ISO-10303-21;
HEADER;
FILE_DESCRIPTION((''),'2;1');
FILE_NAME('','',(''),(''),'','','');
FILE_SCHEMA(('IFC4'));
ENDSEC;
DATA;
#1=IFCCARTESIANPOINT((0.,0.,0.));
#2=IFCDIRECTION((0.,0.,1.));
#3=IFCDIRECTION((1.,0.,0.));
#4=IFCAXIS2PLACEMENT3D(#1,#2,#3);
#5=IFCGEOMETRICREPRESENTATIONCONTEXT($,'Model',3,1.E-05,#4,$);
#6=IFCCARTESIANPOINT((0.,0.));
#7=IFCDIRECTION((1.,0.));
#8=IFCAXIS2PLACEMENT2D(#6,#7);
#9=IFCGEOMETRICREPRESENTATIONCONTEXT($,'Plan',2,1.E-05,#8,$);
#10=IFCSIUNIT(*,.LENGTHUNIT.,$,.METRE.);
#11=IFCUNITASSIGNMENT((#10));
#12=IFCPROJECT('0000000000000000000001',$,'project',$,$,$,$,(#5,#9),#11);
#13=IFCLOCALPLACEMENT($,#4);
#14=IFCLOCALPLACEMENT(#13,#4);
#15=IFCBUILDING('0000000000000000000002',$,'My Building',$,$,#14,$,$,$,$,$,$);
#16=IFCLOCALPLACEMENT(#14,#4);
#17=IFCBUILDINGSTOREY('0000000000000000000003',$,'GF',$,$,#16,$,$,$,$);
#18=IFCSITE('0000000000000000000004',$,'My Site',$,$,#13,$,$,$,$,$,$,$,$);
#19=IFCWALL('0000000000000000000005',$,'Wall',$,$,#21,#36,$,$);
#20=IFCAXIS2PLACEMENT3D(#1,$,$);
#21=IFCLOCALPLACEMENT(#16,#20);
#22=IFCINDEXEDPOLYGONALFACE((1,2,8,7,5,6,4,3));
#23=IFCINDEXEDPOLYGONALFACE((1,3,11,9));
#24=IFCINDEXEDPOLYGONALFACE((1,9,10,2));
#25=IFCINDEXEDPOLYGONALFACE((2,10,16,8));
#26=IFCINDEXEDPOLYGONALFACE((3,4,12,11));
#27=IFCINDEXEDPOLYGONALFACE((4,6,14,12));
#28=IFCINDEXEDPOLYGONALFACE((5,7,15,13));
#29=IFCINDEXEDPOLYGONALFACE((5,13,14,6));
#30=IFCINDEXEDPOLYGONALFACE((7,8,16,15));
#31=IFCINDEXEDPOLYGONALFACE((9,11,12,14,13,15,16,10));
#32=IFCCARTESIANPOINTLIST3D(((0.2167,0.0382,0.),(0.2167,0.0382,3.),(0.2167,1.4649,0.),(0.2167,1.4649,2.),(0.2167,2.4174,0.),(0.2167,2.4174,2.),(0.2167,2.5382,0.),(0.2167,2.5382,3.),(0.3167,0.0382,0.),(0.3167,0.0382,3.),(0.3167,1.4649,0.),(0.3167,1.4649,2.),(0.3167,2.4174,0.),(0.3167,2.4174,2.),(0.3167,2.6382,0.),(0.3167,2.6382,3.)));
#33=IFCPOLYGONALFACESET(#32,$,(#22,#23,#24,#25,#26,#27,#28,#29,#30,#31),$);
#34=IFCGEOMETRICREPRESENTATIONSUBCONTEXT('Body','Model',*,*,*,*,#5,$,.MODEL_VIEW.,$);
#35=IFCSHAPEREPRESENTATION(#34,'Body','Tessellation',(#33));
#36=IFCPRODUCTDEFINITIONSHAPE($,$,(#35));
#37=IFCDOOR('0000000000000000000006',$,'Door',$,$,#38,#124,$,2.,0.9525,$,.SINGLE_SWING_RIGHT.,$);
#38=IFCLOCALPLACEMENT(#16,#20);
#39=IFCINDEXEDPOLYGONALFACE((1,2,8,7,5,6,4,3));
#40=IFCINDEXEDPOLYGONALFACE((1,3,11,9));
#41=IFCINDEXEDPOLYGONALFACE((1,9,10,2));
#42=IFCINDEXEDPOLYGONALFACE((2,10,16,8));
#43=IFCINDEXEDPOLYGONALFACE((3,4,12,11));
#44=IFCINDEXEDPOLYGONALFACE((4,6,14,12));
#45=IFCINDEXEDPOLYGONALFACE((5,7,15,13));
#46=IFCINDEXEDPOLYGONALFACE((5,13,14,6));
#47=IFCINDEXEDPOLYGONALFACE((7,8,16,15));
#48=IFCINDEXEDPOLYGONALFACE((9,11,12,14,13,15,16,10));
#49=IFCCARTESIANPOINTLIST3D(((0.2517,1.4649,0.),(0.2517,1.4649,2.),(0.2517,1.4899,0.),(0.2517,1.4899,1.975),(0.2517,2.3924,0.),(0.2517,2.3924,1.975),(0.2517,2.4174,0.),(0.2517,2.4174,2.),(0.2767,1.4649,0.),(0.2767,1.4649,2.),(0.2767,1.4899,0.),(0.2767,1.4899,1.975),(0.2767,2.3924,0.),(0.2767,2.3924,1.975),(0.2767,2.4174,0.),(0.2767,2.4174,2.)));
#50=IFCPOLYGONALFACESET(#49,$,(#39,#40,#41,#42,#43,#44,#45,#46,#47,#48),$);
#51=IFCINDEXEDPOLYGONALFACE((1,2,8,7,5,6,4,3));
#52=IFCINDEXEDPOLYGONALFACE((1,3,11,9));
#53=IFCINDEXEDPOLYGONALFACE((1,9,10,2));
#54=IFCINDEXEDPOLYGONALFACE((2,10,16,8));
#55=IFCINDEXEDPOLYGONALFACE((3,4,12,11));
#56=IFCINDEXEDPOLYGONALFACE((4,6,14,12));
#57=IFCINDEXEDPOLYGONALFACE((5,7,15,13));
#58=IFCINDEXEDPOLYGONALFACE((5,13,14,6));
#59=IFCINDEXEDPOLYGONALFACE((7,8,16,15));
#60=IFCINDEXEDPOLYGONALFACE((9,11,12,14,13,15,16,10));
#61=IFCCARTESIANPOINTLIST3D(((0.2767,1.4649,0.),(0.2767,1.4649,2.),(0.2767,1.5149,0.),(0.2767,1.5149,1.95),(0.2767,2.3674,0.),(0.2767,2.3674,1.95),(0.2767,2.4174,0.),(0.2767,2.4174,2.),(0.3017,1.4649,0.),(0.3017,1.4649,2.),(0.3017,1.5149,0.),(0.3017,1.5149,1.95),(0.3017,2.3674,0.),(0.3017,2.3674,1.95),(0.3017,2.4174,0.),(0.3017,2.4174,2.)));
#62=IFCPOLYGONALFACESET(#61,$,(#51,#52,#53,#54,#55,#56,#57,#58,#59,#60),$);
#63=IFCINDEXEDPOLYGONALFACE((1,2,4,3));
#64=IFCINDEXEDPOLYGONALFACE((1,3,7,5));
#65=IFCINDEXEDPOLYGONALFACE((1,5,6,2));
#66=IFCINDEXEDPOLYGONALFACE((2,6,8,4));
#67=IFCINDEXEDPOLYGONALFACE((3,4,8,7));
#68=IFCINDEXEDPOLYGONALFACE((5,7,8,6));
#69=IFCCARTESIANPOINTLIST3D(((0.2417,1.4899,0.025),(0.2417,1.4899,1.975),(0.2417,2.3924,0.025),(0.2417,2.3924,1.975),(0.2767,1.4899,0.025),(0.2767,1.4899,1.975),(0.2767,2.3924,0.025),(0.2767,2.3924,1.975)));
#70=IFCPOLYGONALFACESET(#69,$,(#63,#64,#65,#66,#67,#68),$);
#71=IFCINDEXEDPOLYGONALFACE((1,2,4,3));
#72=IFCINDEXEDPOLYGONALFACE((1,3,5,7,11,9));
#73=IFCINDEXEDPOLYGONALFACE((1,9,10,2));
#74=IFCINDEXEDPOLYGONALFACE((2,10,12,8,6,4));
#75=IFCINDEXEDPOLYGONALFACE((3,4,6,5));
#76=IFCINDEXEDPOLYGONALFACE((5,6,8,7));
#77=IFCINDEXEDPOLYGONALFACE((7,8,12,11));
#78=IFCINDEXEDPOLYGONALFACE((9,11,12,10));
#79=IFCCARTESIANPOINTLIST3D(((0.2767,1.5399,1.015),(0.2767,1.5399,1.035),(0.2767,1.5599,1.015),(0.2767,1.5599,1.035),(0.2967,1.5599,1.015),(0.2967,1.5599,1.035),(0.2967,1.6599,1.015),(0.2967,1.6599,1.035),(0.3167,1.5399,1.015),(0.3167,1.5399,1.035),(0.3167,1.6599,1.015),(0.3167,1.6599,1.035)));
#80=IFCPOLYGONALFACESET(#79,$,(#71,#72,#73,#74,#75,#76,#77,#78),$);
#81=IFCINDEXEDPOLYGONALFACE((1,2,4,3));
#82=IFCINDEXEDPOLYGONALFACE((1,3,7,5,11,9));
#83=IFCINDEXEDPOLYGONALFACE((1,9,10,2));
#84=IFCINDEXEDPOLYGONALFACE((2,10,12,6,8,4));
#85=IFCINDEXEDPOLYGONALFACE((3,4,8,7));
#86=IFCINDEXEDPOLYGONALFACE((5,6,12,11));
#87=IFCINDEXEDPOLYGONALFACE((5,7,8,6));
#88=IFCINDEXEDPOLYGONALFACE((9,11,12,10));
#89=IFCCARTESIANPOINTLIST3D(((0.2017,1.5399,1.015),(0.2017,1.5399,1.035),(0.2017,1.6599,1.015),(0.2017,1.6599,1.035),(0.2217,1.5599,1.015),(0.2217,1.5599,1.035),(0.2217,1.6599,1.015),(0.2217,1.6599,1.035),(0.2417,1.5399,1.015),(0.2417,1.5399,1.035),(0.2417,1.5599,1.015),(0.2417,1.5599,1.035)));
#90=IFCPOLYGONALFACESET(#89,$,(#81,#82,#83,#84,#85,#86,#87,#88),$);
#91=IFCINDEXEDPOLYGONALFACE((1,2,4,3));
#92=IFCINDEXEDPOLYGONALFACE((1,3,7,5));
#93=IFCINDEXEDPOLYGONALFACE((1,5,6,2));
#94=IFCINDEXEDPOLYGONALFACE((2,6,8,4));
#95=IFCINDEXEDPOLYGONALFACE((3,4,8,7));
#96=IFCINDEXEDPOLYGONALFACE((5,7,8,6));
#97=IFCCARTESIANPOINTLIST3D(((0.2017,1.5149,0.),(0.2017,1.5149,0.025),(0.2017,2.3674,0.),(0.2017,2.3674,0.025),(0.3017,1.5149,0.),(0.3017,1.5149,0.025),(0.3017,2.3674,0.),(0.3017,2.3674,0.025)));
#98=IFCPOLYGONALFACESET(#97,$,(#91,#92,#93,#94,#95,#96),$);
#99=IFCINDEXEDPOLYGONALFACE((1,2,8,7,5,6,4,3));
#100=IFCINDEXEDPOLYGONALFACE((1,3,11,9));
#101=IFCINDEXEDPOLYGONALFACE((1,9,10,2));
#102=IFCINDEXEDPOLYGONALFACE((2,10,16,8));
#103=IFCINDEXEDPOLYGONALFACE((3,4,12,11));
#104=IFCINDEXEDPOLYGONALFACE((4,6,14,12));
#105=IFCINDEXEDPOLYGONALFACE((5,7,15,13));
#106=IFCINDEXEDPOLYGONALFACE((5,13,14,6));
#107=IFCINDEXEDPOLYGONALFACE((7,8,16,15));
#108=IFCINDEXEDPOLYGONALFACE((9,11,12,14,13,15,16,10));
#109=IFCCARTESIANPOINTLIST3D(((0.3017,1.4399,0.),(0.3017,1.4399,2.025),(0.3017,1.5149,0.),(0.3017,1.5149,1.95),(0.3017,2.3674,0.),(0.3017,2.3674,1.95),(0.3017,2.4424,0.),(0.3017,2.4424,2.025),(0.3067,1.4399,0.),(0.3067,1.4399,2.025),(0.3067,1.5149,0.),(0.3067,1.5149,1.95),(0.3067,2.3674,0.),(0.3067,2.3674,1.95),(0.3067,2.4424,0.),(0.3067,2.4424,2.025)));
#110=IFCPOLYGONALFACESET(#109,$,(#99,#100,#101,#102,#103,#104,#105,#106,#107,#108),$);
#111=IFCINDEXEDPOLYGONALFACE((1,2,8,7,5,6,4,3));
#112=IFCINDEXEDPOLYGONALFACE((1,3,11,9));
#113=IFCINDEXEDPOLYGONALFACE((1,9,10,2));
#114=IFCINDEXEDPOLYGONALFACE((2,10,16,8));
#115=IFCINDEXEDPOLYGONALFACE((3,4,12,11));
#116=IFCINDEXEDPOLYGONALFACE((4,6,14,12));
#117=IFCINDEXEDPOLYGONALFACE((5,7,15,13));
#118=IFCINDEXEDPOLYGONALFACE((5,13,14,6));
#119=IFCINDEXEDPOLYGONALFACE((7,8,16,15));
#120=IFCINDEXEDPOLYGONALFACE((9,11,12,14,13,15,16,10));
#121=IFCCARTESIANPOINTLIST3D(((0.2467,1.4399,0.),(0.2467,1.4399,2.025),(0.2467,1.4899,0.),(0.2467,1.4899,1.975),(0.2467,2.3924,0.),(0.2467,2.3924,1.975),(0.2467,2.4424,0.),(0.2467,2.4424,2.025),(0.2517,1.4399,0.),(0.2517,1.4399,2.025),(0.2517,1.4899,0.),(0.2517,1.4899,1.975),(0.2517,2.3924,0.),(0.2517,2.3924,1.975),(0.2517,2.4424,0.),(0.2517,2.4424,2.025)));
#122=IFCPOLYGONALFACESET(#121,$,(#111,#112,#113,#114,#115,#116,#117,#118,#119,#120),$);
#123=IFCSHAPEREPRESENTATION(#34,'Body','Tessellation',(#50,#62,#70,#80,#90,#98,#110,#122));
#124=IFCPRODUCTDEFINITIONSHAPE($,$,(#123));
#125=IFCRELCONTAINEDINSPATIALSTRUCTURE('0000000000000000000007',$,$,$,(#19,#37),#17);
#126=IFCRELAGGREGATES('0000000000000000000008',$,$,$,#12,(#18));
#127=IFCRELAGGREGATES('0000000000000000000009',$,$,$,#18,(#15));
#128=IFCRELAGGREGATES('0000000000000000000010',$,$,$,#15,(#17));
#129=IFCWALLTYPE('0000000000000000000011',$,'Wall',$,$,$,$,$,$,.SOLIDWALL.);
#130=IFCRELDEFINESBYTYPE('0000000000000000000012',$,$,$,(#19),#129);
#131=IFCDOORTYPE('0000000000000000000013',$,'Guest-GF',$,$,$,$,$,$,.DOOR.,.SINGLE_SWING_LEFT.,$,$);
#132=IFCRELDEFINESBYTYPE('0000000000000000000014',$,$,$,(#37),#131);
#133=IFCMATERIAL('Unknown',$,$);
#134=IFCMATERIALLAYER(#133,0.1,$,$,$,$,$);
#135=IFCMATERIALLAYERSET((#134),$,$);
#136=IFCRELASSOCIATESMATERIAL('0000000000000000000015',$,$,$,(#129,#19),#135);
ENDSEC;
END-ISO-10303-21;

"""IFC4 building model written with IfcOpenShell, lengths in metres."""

from ifc_helpers import new_model, entity, si_unit, frame, origin_with_axes, origin_2d_with_axis, place, context, subcontext, project, spatial, line, indexed_curve, outline, extrude, shape, source, transform, mapped, material, layer, layer_set, layer_usage, type_object, type_shapes, element, fill, save


model = new_model("IFC4")

# Units and contexts
model_context = context("Model", 3, precision=1e-05, world=origin_with_axes())
plan_context = context("Plan", 2, precision=1e-05, world=origin_2d_with_axis())
body_context_1 = subcontext(model_context, "Body", "Model", "MODEL_VIEW")
body_context_2 = subcontext(plan_context, "Body", "Plan", "PLAN_VIEW")
ifc_project = project(units=[si_unit("LENGTHUNIT", "METRE")], contexts=[model_context, plan_context])

# Site, building, storey
site_placement = place(None, origin_with_axes())
site = spatial("IfcSite", under=ifc_project, at=site_placement, Name="My Site")
building_placement = place(site_placement, origin_with_axes())
building = spatial("IfcBuilding", under=site, at=building_placement, Name="My Building")
storey_placement = place(building_placement, origin_with_axes())
storey = spatial("IfcBuildingStorey", under=building, at=storey_placement, Name="GF")

# Shared definitions
ifc_material = material(Name="Unknown")

# Shared definitions
ifc_layer_1 = layer(ifc_material, 0.1)
ifc_layer_set_1 = layer_set([ifc_layer_1])
wall_type = type_object("IfcWallType", Name="Wall", PredefinedType="SOLIDWALL", material=ifc_layer_set_1)

# Wall, opening, door
ifc_layer_usage_1 = layer_usage(ifc_layer_set_1, "AXIS2", "POSITIVE", 0.0)
wall_1_placement = place(storey_placement, frame((0.3167, 0.0382, 0.0), z_axis=(0.0, 0.0, 1.0), x_axis=(0.0, 1.0, 0.0)))
wall_1 = element("IfcWall", 1, at=wall_1_placement, inside=storey, type_object=wall_type, material=ifc_layer_usage_1, Name="Wall", context=body_context_1, shape_type="SweptSolid", body=[
    extrude(outline(indexed_curve([(0.0, 0.0), (0.0, 0.1), (2.5, 0.1), (2.6, 0.0)], segments=[line(1, 2, 3, 4, 1)])), origin_with_axes(), (0.0, 0.0, 1.0), 3.0),
])
shared_shape_1 = source(origin_with_axes(), body_context_1, "Body", "SweptSolid", [
    extrude(outline(indexed_curve([(0.0, 0.0), (0.9525, 0.0), (0.9525, 2.0), (0.0, 2.0)], segments=[line(1, 2, 3, 4, 1)])), frame((0.0, -0.6, 0.0), z_axis=(0.0, -1.0, 0.0), x_axis=(1.0, 0.0, 0.0)), (0.0, 0.0, -1.0), 1.2),
])
opening_1_placement = place(wall_1_placement, frame((1.4267, 0.015, 0.0), z_axis=(0.0, 0.0, 1.0), x_axis=(1.0, 0.0, 0.0)))
opening_1 = element("IfcOpeningElement", 2, at=opening_1_placement, cuts=wall_1, PredefinedType="OPENING", context=body_context_1, shape_type="MappedRepresentation", body=[
    mapped(shared_shape_1, transform((0.0, 0.0, 0.0), x_axis=(1.0, 0.0, 0.0), y_axis=(0.0, 1.0, 0.0), z_axis=(0.0, 0.0, 1.0), scale=1.0)),
])
door_type_1 = type_object("IfcDoorType", Name="Guest-GF", OperationType="SINGLE_SWING_LEFT", PredefinedType="DOOR")
shared_shape_2 = source(origin_with_axes(), body_context_1, "Body", "SweptSolid", [
    extrude(outline(indexed_curve([(0.0, 0.0), (0.0, 2.0), (0.9525, 2.0), (0.9525, 0.0), (0.9275, 0.0), (0.9275, 1.975), (0.025, 1.975), (0.025, 0.0)], segments=[line(1, 2, 3, 4, 5, 6, 7, 8, 1)])), frame((0.0, 0.025, 0.0), z_axis=(0.0, -1.0, 0.0), x_axis=(1.0, 0.0, 0.0)), (0.0, 0.0, -1.0), 0.025),
    extrude(outline(indexed_curve([(0.0, 0.0), (0.0, 2.0), (0.9525, 2.0), (0.9525, 0.0), (0.9025, 0.0), (0.9025, 1.95), (0.05, 1.95), (0.05, 0.0)], segments=[line(1, 2, 3, 4, 5, 6, 7, 8, 1)])), frame((0.0, 0.0, 0.0), z_axis=(0.0, -1.0, 0.0), x_axis=(1.0, 0.0, 0.0)), (0.0, 0.0, -1.0), 0.025),
    extrude(outline(indexed_curve([(0.0, 0.0), (0.9025, 0.0), (0.9025, 0.035), (0.0, 0.035)], segments=[line(1, 2, 3, 4, 1)])), frame((0.025, 0.025, 0.025), z_axis=(0.0, 0.0, 1.0), x_axis=(1.0, 0.0, 0.0)), (0.0, 0.0, 1.0), 1.95),
    extrude(outline(indexed_curve([(0.0, 0.0), (0.0, -0.04), (0.12, -0.04), (0.12, -0.02), (0.02, -0.02), (0.02, 0.0)], segments=[line(1, 2, 3, 4, 5, 6, 1)])), frame((0.075, 0.025, 1.015), z_axis=(0.0, 0.0, 1.0), x_axis=(1.0, 0.0, 0.0)), (0.0, 0.0, 1.0), 0.02),
    extrude(outline(indexed_curve([(0.0, 0.0), (0.0, 0.04), (0.12, 0.04), (0.12, 0.02), (0.02, 0.02), (0.02, 0.0)], segments=[line(1, 2, 3, 4, 5, 6, 1)])), frame((0.075, 0.06, 1.015), z_axis=(0.0, 0.0, 1.0), x_axis=(1.0, 0.0, 0.0)), (0.0, 0.0, 1.0), 0.02),
    extrude(outline(indexed_curve([(0.0, 0.0), (0.8525, 0.0), (0.8525, 0.1), (0.0, 0.1)], segments=[line(1, 2, 3, 4, 1)])), frame((0.05, 0.0, 0.0), z_axis=(0.0, 0.0, 1.0), x_axis=(1.0, 0.0, 0.0)), (0.0, 0.0, 1.0), 0.025),
    extrude(outline(indexed_curve([(0.0, 0.0), (0.0, 2.025), (1.0025, 2.025), (1.0025, 0.0), (0.9275, 0.0), (0.9275, 1.95), (0.075, 1.95), (0.075, 0.0)], segments=[line(1, 2, 3, 4, 5, 6, 7, 8, 1)])), frame((-0.025, -0.005, 0.0), z_axis=(0.0, -1.0, 0.0), x_axis=(1.0, 0.0, 0.0)), (0.0, 0.0, -1.0), 0.005),
    extrude(outline(indexed_curve([(0.0, 0.0), (0.0, 2.025), (1.0025, 2.025), (1.0025, 0.0), (0.9525, 0.0), (0.9525, 1.975), (0.05, 1.975), (0.05, 0.0)], segments=[line(1, 2, 3, 4, 5, 6, 7, 8, 1)])), frame((-0.025, 0.05, 0.0), z_axis=(0.0, -1.0, 0.0), x_axis=(1.0, 0.0, 0.0)), (0.0, 0.0, -1.0), 0.005),
])
shared_shape_3 = source(origin_with_axes(), body_context_2, "Body", "Curve2D", [
    entity("IfcIndexedPolyCurve", entity("IfcCartesianPointList2D", [[0.0, 0.0], [0.0, 0.05], [0.025, 0.05], [0.025, 0.025], [0.05, 0.025], [0.05, 0.0]]), [entity("IfcLineIndex", [1, 2, 3, 4, 5, 6, 1])]),
    entity("IfcIndexedPolyCurve", entity("IfcCartesianPointList2D", [[0.9525, 0.0], [0.9525, 0.05], [0.9275, 0.05], [0.9275, 0.025], [0.9025, 0.025], [0.9025, 0.0]]), [entity("IfcLineIndex", [1, 2, 3, 4, 5, 6, 1])]),
    entity("IfcTrimmedCurve", entity("IfcEllipse", entity("IfcAxis2Placement2D", entity("IfcCartesianPoint", [0.8925, 0.05]), entity("IfcDirection", [1.0, 0.0])), 0.8675, 0.9025), [entity("IfcCartesianPoint", [0.8925, 0.9525])], [entity("IfcCartesianPoint", [0.025, 0.05])], True, "CARTESIAN"),
    entity("IfcIndexedPolyCurve", entity("IfcCartesianPointList2D", [[0.9275, 0.05], [0.8925, 0.05], [0.8925, 0.9525], [0.9275, 0.9525]]), [entity("IfcLineIndex", [1, 2, 3, 4, 1])]),
])
type_shapes(door_type_1, [shared_shape_2, shared_shape_3])
door_1_placement = place(opening_1_placement, frame((0.0, 0.0, 0.0), z_axis=(0.0, 0.0, 1.0), x_axis=(1.0, 0.0, 0.0)))
door_1 = element("IfcDoor", 3, at=door_1_placement, inside=storey, type_object=door_type_1, Name="Door", OperationType="SINGLE_SWING_RIGHT", OverallHeight=2.0, OverallWidth=0.9525, shapes=[
    shape(body_context_1, "Body", "MappedRepresentation", [mapped(shared_shape_2, transform((0.0, 0.0, 0.0), x_axis=(1.0, 0.0, 0.0), y_axis=(0.0, 1.0, 0.0), z_axis=(0.0, 0.0, 1.0), scale=1.0))]),
    shape(body_context_2, "Body", "MappedRepresentation", [mapped(shared_shape_3, transform((0.0, 0.0, 0.0), x_axis=(1.0, 0.0, 0.0), y_axis=(0.0, 1.0, 0.0), z_axis=(0.0, 0.0, 1.0), scale=1.0))]),
])
fill(opening_1, door_1)

save(model, "model.ifc")
